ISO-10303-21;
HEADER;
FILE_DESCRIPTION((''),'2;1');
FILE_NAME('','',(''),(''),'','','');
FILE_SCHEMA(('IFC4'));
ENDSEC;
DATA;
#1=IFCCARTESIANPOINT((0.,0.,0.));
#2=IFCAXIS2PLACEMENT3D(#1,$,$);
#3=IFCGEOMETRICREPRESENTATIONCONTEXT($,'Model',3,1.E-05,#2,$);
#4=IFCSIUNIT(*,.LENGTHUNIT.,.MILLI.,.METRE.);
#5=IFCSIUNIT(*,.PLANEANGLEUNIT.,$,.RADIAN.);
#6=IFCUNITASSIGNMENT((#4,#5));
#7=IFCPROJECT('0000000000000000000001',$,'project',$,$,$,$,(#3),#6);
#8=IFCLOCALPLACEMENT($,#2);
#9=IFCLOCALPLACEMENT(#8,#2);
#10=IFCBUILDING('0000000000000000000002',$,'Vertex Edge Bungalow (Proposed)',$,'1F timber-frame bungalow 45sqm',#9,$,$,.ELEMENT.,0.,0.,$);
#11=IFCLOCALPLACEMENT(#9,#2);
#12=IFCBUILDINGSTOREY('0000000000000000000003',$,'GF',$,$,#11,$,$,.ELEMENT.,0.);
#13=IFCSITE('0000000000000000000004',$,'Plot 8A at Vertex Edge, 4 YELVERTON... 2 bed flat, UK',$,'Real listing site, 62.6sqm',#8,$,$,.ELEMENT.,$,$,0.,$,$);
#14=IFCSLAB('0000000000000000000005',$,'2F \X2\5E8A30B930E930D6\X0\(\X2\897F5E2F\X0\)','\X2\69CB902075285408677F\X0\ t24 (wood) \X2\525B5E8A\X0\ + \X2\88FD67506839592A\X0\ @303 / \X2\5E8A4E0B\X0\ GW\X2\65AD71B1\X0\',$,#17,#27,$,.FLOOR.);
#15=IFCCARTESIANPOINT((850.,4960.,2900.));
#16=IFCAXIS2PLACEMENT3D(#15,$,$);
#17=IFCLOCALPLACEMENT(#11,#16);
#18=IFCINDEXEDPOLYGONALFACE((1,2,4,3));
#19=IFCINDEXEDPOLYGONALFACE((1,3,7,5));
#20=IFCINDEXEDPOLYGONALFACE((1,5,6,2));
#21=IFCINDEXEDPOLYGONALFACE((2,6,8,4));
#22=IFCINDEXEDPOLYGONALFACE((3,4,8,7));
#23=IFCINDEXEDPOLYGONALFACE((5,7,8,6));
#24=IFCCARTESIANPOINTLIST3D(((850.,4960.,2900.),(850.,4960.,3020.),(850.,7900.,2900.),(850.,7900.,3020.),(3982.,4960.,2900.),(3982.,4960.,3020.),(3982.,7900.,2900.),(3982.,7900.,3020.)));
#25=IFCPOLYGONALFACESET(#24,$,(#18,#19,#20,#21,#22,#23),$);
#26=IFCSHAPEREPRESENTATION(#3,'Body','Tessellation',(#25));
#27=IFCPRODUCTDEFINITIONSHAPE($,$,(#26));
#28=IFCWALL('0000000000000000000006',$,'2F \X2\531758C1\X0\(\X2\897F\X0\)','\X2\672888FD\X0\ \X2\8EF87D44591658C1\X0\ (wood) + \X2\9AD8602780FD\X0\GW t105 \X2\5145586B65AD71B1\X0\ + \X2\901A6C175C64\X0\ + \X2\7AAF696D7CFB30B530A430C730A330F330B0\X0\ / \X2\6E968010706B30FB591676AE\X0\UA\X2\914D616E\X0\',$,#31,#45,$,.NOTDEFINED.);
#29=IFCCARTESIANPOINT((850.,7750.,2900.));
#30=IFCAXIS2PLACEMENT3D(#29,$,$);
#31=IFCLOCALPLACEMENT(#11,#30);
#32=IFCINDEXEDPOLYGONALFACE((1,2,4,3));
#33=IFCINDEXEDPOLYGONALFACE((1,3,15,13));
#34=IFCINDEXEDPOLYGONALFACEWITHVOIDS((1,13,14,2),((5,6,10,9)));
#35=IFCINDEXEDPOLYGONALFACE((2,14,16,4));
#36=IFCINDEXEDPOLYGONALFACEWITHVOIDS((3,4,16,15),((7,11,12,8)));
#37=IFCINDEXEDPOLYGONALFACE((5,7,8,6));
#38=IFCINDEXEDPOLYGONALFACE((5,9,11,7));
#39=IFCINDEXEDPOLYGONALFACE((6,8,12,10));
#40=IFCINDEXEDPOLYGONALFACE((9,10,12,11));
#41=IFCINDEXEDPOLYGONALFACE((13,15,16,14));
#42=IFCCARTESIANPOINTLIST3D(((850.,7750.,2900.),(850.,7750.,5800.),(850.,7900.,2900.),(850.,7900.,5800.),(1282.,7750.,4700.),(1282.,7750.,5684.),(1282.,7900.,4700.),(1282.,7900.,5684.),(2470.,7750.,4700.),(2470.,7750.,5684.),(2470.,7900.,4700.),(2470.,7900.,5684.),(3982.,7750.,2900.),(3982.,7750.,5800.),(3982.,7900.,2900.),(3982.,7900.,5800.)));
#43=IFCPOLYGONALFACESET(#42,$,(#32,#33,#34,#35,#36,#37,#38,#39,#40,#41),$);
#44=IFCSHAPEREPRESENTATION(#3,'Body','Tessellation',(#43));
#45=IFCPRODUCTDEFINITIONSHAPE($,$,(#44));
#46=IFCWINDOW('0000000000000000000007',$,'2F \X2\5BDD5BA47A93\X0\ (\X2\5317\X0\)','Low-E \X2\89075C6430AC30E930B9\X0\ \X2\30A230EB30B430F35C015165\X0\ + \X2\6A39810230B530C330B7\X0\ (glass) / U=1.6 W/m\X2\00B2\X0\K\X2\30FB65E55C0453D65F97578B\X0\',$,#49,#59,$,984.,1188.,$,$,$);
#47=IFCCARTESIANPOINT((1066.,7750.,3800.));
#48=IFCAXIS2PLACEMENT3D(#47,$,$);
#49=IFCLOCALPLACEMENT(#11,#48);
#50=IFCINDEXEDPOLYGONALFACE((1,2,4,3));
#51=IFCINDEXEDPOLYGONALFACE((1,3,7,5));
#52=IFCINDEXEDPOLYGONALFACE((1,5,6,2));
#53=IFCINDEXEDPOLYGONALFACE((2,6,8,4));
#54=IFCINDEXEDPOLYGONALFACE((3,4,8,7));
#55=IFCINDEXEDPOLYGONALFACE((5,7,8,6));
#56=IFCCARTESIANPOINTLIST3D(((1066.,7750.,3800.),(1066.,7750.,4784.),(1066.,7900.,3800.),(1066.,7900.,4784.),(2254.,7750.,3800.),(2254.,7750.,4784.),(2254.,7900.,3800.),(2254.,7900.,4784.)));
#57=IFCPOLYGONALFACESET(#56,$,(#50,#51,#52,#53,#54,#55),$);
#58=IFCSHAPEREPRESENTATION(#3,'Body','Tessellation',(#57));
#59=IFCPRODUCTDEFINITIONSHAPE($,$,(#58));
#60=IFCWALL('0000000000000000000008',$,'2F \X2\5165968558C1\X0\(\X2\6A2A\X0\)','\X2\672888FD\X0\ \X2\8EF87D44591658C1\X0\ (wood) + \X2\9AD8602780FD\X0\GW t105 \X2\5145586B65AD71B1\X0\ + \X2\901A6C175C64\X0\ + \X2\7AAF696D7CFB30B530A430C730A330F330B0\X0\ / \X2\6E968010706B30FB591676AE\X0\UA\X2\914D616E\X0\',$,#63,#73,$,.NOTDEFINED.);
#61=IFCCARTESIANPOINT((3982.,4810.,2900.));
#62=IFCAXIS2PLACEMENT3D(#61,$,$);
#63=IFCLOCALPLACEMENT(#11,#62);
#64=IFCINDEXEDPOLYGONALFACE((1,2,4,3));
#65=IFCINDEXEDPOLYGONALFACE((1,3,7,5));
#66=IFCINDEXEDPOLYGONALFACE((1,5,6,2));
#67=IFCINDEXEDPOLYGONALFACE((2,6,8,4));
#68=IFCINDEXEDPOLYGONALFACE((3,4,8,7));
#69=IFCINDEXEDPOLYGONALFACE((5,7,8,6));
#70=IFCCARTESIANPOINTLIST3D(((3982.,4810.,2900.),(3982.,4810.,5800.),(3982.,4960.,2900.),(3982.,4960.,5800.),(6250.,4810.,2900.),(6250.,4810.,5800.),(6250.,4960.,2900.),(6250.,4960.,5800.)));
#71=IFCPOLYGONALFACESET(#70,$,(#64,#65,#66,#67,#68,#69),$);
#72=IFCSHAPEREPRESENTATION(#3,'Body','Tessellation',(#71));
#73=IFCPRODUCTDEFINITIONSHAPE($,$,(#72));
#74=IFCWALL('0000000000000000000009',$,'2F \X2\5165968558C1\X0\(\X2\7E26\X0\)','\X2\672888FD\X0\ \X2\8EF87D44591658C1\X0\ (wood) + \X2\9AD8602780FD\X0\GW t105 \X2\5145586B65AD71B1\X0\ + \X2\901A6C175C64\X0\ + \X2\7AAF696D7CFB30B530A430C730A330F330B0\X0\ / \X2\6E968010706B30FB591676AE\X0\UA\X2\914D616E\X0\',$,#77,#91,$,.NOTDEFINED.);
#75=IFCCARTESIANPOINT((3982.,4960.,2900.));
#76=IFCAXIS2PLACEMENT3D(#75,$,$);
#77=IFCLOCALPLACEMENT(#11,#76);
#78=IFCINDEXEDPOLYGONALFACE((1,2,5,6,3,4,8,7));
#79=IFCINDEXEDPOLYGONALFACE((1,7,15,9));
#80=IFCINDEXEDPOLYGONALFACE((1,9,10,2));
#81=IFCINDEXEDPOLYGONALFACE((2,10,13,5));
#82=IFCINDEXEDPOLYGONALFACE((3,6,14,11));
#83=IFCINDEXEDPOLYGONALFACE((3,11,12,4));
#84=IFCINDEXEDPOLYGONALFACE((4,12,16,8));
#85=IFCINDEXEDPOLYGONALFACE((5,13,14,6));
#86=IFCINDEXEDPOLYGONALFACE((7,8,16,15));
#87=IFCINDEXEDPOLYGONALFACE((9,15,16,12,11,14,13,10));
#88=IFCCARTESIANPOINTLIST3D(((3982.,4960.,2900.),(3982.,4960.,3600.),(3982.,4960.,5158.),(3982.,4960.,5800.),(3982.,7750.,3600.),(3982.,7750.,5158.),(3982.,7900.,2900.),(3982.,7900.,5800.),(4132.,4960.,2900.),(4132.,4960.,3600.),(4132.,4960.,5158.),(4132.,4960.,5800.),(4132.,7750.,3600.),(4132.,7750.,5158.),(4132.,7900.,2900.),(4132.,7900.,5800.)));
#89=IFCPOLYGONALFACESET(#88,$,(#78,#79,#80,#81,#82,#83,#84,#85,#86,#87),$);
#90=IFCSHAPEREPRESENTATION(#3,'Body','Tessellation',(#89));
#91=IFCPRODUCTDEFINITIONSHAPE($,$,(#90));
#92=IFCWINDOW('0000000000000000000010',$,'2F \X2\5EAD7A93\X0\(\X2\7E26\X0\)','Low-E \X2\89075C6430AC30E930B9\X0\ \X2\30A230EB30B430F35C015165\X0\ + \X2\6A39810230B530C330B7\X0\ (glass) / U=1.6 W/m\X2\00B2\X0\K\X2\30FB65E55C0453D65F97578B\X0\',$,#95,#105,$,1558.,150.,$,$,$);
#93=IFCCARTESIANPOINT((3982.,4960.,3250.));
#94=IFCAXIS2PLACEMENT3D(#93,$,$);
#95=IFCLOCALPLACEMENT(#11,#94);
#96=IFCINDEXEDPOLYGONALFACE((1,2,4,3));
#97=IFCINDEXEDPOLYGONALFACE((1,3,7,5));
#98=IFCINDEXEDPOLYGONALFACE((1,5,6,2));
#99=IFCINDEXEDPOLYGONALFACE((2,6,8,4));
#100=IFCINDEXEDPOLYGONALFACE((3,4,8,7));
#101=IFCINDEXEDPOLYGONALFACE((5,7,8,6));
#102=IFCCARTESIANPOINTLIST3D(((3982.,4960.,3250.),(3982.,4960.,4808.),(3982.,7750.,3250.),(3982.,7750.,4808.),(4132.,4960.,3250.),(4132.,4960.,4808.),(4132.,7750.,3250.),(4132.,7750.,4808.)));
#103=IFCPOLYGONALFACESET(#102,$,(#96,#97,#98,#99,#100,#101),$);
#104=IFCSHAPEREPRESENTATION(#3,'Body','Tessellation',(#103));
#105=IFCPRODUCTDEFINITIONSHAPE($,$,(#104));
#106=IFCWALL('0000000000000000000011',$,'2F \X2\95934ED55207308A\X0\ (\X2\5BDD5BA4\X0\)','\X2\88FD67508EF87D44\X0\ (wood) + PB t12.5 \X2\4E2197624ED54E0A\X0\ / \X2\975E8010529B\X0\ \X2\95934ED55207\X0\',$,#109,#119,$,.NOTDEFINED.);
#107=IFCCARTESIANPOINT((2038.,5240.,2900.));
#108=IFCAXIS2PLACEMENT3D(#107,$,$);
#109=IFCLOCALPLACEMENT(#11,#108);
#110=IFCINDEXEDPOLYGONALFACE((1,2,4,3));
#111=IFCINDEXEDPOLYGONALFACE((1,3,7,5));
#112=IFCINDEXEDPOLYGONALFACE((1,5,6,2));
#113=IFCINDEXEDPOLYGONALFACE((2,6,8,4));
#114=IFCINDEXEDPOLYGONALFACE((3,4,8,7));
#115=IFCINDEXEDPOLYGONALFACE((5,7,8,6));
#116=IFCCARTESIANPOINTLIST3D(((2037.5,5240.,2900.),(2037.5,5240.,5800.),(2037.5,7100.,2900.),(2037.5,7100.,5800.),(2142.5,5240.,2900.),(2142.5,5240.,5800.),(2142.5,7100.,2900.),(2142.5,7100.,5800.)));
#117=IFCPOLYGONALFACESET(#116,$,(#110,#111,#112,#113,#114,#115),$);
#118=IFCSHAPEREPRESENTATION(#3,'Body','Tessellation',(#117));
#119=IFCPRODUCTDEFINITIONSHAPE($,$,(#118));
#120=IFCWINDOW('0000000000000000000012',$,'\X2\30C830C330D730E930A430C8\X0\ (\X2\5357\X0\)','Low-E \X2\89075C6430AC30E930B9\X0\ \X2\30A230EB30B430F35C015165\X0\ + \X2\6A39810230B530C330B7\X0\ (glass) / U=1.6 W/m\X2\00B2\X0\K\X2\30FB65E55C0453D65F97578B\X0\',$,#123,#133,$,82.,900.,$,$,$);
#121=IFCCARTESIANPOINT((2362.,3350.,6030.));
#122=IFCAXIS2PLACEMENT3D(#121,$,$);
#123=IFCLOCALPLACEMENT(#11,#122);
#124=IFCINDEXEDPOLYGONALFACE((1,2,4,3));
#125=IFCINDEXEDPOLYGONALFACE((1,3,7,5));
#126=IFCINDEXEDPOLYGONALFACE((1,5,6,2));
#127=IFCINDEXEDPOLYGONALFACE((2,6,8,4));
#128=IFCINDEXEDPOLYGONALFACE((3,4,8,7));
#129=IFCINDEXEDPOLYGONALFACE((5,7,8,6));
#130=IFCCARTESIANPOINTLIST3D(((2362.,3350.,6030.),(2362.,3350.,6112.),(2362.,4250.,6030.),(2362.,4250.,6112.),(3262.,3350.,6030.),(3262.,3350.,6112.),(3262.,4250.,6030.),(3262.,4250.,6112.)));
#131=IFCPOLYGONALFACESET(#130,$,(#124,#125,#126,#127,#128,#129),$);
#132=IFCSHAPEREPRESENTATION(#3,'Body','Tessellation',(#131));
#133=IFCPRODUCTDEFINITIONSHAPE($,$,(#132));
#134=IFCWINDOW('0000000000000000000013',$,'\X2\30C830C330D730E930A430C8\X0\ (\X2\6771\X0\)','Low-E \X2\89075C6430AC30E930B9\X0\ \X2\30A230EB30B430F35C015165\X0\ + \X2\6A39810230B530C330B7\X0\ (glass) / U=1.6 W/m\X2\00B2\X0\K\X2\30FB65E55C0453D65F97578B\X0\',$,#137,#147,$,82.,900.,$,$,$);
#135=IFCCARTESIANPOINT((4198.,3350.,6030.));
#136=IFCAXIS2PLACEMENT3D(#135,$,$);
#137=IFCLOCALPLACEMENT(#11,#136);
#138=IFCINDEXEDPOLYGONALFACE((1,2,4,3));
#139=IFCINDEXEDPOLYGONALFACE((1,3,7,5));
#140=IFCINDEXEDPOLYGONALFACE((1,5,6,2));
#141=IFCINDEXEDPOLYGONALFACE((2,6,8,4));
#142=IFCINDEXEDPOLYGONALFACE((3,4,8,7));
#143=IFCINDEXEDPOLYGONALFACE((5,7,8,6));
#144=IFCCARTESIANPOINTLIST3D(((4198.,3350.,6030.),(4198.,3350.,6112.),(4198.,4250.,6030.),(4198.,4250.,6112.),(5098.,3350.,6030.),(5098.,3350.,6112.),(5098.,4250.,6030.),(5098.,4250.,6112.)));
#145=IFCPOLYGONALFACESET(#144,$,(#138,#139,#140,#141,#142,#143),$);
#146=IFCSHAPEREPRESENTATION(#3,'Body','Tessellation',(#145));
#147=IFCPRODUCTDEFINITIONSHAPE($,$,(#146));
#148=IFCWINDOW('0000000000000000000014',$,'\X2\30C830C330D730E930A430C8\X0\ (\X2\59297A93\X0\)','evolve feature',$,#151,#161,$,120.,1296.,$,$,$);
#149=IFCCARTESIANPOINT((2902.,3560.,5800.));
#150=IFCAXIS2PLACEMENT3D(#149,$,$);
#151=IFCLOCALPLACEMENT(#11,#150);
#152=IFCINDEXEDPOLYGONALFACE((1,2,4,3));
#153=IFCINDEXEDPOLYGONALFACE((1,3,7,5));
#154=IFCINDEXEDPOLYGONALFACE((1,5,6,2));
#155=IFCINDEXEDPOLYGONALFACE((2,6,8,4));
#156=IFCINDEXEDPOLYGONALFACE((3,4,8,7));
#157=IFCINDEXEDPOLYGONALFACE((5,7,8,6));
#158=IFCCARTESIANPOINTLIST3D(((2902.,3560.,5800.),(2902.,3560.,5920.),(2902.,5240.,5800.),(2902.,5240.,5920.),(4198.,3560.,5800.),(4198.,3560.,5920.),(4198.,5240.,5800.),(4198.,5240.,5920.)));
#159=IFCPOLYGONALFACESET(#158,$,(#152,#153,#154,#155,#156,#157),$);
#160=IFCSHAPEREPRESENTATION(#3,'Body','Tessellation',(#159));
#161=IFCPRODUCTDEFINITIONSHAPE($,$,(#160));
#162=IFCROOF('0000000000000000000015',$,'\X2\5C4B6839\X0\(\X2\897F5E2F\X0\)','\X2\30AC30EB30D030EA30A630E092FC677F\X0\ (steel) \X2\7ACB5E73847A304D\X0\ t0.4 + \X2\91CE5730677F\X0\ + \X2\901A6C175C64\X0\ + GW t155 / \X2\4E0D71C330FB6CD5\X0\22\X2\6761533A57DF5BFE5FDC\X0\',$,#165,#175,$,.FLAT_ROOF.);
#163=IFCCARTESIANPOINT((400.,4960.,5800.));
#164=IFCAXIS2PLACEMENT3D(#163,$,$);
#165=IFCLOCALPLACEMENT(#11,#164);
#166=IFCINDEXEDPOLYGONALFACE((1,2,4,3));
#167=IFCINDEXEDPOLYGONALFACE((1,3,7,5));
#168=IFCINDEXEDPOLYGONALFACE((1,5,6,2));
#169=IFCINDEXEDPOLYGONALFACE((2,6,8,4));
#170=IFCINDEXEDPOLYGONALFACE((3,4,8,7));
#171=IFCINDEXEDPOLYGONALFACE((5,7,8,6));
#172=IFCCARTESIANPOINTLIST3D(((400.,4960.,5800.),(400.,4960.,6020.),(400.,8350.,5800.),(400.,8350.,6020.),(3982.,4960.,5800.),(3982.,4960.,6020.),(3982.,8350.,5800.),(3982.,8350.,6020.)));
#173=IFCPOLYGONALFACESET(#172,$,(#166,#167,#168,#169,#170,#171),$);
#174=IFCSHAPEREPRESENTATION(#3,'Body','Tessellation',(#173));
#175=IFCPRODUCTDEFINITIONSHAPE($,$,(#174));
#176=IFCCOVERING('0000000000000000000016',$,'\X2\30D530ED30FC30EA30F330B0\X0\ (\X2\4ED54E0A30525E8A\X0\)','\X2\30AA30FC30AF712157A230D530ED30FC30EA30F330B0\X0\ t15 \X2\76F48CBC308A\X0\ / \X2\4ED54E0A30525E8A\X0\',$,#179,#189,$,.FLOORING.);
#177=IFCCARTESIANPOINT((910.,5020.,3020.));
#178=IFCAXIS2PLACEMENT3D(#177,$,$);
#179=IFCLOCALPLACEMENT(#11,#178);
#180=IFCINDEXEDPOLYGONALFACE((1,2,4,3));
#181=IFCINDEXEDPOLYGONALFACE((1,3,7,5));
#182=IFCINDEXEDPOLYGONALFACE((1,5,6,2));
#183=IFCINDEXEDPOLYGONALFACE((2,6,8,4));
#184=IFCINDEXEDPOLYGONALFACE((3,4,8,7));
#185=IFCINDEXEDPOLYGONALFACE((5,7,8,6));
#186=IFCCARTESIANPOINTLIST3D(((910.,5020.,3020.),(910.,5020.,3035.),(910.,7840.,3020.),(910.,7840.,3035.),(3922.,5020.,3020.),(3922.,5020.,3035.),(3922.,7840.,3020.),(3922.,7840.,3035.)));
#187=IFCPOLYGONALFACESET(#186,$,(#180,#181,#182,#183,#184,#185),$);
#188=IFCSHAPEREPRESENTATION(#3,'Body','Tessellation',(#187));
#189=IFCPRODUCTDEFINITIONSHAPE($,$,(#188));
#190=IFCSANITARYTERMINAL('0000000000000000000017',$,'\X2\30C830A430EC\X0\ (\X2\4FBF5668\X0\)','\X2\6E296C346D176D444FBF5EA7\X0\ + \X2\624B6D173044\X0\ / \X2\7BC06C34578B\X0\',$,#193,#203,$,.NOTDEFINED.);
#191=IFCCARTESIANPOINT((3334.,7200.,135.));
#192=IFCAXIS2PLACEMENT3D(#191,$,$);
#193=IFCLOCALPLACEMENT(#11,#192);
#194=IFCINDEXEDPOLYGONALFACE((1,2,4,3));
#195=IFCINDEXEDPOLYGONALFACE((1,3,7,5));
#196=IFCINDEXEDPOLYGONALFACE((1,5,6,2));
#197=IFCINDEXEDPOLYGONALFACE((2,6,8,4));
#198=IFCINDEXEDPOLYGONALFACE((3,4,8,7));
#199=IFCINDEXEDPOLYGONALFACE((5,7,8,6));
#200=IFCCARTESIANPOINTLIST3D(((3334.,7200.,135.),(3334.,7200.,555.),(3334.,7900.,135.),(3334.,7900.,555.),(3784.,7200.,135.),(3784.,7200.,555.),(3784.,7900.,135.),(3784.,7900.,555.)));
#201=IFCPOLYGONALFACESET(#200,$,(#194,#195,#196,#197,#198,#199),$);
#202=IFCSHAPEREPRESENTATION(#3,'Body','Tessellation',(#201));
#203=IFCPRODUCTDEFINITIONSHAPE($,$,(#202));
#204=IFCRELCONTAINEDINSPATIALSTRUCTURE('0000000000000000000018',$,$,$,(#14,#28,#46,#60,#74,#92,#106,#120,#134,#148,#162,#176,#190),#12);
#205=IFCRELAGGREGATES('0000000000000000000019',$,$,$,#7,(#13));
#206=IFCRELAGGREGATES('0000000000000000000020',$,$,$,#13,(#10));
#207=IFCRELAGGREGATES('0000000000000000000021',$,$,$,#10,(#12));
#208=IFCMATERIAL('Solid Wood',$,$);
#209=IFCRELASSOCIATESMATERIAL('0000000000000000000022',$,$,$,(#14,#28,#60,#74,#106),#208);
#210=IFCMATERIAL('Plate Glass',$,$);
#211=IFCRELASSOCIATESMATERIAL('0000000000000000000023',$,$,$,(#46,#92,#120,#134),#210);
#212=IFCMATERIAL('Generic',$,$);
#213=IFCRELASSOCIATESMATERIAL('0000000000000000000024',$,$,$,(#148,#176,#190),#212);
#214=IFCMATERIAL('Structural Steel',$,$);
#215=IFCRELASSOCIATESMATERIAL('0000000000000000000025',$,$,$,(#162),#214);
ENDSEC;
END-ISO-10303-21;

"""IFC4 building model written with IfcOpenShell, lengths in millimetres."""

from ifc_helpers import new_model, si_unit, frame, frame_2d, origin, place, context, project, spatial, rectangle, extrude, material, element, fill, save


model = new_model("IFC4")

# Units and contexts
model_context = context("Model", 3, precision=1e-05, world=origin())
ifc_project = project(units=[si_unit("LENGTHUNIT", "METRE", prefix="MILLI"), si_unit("PLANEANGLEUNIT", "RADIAN")], contexts=[model_context])

# Site, building, storey
site_placement = place(None, origin())
site = spatial("IfcSite", under=ifc_project, at=site_placement, Name="Plot 8A at Vertex Edge, 4 YELVERTON... 2 bed flat, UK", ObjectType="Real listing site, 62.6sqm", CompositionType="ELEMENT", RefElevation=0.0)
building_placement = place(site_placement, origin())
building = spatial("IfcBuilding", under=site, at=building_placement, Name="Vertex Edge Bungalow (Proposed)", ObjectType="1F timber-frame bungalow 45sqm", CompositionType="ELEMENT", ElevationOfRefHeight=0.0, ElevationOfTerrain=0.0)
storey_placement = place(building_placement, origin())
storey = spatial("IfcBuildingStorey", under=building, at=storey_placement, Name="GF", CompositionType="ELEMENT", Elevation=0.0)

# Slab
ifc_material_1 = material(Name="Solid Wood")
slab_placement = place(storey_placement, frame((850.0, 4960.0, 2900.0)))
element("IfcSlab", 1, at=slab_placement, inside=storey, material=ifc_material_1, Name="2F 床スラブ(西帯)", Description="構造用合板 t24 (wood) 剛床 + 製材根太 @303 / 床下 GW断熱", PredefinedType="FLOOR", context=model_context, shape_type="SweptSolid", body=[
    extrude(rectangle(XDim=3132.0, YDim=2940.0, at=frame_2d((1566.0, 1470.0))), frame((850.0, 4960.0, 2900.0)), (0.0, 0.0, 1.0), 120.0),
])

# Wall, opening, window
wall_1_placement = place(storey_placement, frame((850.0, 7750.0, 2900.0)))
wall_1 = element("IfcWall", 2, at=wall_1_placement, inside=storey, material=ifc_material_1, Name="2F 北壁(西)", Description="木製 軸組外壁 (wood) + 高性能GW t105 充填断熱 + 通気層 + 窯業系サイディング / 準耐火・外皮UA配慮", PredefinedType="NOTDEFINED", context=model_context, shape_type="SweptSolid", body=[
    extrude(rectangle(XDim=3132.0, YDim=150.0, at=frame_2d((1566.0, 75.0))), frame((850.0, 7750.0, 2900.0)), (0.0, 0.0, 1.0), 2900.0),
])
opening_1_placement = place(storey_placement, frame((1066.0, 7750.0, 3800.0)))
opening_1 = element("IfcOpeningElement", 3, at=opening_1_placement, cuts=wall_1, PredefinedType="NOTDEFINED", context=model_context, shape_type="SweptSolid", body=[
    extrude(rectangle(XDim=1188.0, YDim=150.0, at=frame_2d((594.0, 75.0))), frame((1066.0, 7750.0, 3800.0)), (0.0, 0.0, 1.0), 984.0),
])
ifc_material_2 = material(Name="Plate Glass")
window_1_placement = place(storey_placement, frame((1066.0, 7750.0, 3800.0)))
window_1 = element("IfcWindow", 4, at=window_1_placement, inside=storey, material=ifc_material_2, Name="2F 寝室窓 (北)", Description="Low-E 複層ガラス アルゴン封入 + 樹脂サッシ (glass) / U=1.6 W/m²K・日射取得型", OverallHeight=984.0, OverallWidth=1188.0, context=model_context, shape_type="SweptSolid", body=[
    extrude(rectangle(XDim=1188.0, YDim=150.0, at=frame_2d((594.0, 75.0))), frame((1066.0, 7750.0, 3800.0)), (0.0, 0.0, 1.0), 984.0),
])
fill(opening_1, window_1)

# Wall
wall_2_placement = place(storey_placement, frame((3982.0, 4810.0, 2900.0)))
element("IfcWall", 5, at=wall_2_placement, inside=storey, material=ifc_material_1, Name="2F 入隅壁(横)", Description="木製 軸組外壁 (wood) + 高性能GW t105 充填断熱 + 通気層 + 窯業系サイディング / 準耐火・外皮UA配慮", PredefinedType="NOTDEFINED", context=model_context, shape_type="SweptSolid", body=[
    extrude(rectangle(XDim=2268.0, YDim=150.0, at=frame_2d((1134.0, 75.0))), frame((3982.0, 4810.0, 2900.0)), (0.0, 0.0, 1.0), 2900.0),
])

# Wall, opening, window
wall_3_placement = place(storey_placement, frame((3982.0, 4960.0, 2900.0)))
wall_3 = element("IfcWall", 6, at=wall_3_placement, inside=storey, material=ifc_material_1, Name="2F 入隅壁(縦)", Description="木製 軸組外壁 (wood) + 高性能GW t105 充填断熱 + 通気層 + 窯業系サイディング / 準耐火・外皮UA配慮", PredefinedType="NOTDEFINED", context=model_context, shape_type="SweptSolid", body=[
    extrude(rectangle(XDim=150.0, YDim=2940.0, at=frame_2d((75.0, 1470.0))), frame((3982.0, 4960.0, 2900.0)), (0.0, 0.0, 1.0), 2900.0),
])
opening_2_placement = place(storey_placement, frame((3982.0, 4960.0, 3250.0)))
opening_2 = element("IfcOpeningElement", 7, at=opening_2_placement, cuts=wall_3, PredefinedType="NOTDEFINED", context=model_context, shape_type="SweptSolid", body=[
    extrude(rectangle(XDim=150.0, YDim=2790.0, at=frame_2d((75.0, 1395.0))), frame((3982.0, 4960.0, 3250.0)), (0.0, 0.0, 1.0), 1558.0),
])
window_2_placement = place(storey_placement, frame((3982.0, 4960.0, 3250.0)))
window_2 = element("IfcWindow", 8, at=window_2_placement, inside=storey, material=ifc_material_2, Name="2F 庭窓(縦)", Description="Low-E 複層ガラス アルゴン封入 + 樹脂サッシ (glass) / U=1.6 W/m²K・日射取得型", OverallHeight=1558.0, OverallWidth=150.0, context=model_context, shape_type="SweptSolid", body=[
    extrude(rectangle(XDim=150.0, YDim=2790.0, at=frame_2d((75.0, 1395.0))), frame((3982.0, 4960.0, 3250.0)), (0.0, 0.0, 1.0), 1558.0),
])
fill(opening_2, window_2)

# Wall
wall_4_placement = place(storey_placement, frame((2038.0, 5240.0, 2900.0)))
element("IfcWall", 9, at=wall_4_placement, inside=storey, material=ifc_material_1, Name="2F 間仕切り (寝室)", Description="製材軸組 (wood) + PB t12.5 両面仕上 / 非耐力 間仕切", PredefinedType="NOTDEFINED", context=model_context, shape_type="SweptSolid", body=[
    extrude(rectangle(XDim=105.0, YDim=1860.0, at=frame_2d((52.0, 930.0))), frame((2038.0, 5240.0, 2900.0)), (0.0, 0.0, 1.0), 2900.0),
])

# Windows
window_3_placement = place(storey_placement, frame((2362.0, 3350.0, 6030.0)))
element("IfcWindow", 10, at=window_3_placement, inside=storey, material=ifc_material_2, Name="トップライト (南)", Description="Low-E 複層ガラス アルゴン封入 + 樹脂サッシ (glass) / U=1.6 W/m²K・日射取得型", OverallHeight=82.0, OverallWidth=900.0, context=model_context, shape_type="SweptSolid", body=[
    extrude(rectangle(XDim=900.0, YDim=900.0, at=frame_2d((450.0, 450.0))), frame((2362.0, 3350.0, 6030.0)), (0.0, 0.0, 1.0), 82.0),
])
window_4_placement = place(storey_placement, frame((4198.0, 3350.0, 6030.0)))
element("IfcWindow", 11, at=window_4_placement, inside=storey, material=ifc_material_2, Name="トップライト (東)", Description="Low-E 複層ガラス アルゴン封入 + 樹脂サッシ (glass) / U=1.6 W/m²K・日射取得型", OverallHeight=82.0, OverallWidth=900.0, context=model_context, shape_type="SweptSolid", body=[
    extrude(rectangle(XDim=900.0, YDim=900.0, at=frame_2d((450.0, 450.0))), frame((4198.0, 3350.0, 6030.0)), (0.0, 0.0, 1.0), 82.0),
])
ifc_material_3 = material(Name="Generic")
window_5_placement = place(storey_placement, frame((2902.0, 3560.0, 5800.0)))
element("IfcWindow", 12, at=window_5_placement, inside=storey, material=ifc_material_3, Name="トップライト (天窓)", Description="evolve feature", OverallHeight=120.0, OverallWidth=1296.0, context=model_context, shape_type="SweptSolid", body=[
    extrude(rectangle(XDim=1296.0, YDim=1680.0, at=frame_2d((648.0, 840.0))), frame((2902.0, 3560.0, 5800.0)), (0.0, 0.0, 1.0), 120.0),
])

# Roof
ifc_material_4 = material(Name="Structural Steel")
for number, where, name in (
    (13, (400.0, 4960.0, 5800.0), "屋根(西帯)"),
):
    element("IfcRoof", number, at=place(storey_placement, frame(where)), inside=storey, material=ifc_material_4, Name=name, Description="ガルバリウム鋼板 (steel) 立平葺き t0.4 + 野地板 + 通気層 + GW t155 / 不燃・法22条区域対応", PredefinedType="FLAT_ROOF", context=model_context, shape_type="SweptSolid", body=[
        extrude(rectangle(XDim=3582.0, YDim=3390.0, at=frame_2d((1791.0, 1695.0))), frame((400.0, 4960.0, 5800.0)), (0.0, 0.0, 1.0), 220.0),
    ])

# Covering
covering_placement = place(storey_placement, frame((910.0, 5020.0, 3020.0)))
element("IfcCovering", 14, at=covering_placement, inside=storey, material=ifc_material_3, Name="フローリング (仕上げ床)", Description="オーク無垢フローリング t15 直貼り / 仕上げ床", PredefinedType="FLOORING", context=model_context, shape_type="SweptSolid", body=[
    extrude(rectangle(XDim=3012.0, YDim=2820.0, at=frame_2d((1506.0, 1410.0))), frame((910.0, 5020.0, 3020.0)), (0.0, 0.0, 1.0), 15.0),
])

# Sanitary terminal
sanitary_terminal_placement = place(storey_placement, frame((3334.0, 7200.0, 135.0)))
element("IfcSanitaryTerminal", 15, at=sanitary_terminal_placement, inside=storey, material=ifc_material_3, Name="トイレ (便器)", Description="温水洗浄便座 + 手洗い / 節水型", PredefinedType="NOTDEFINED", context=model_context, shape_type="SweptSolid", body=[
    extrude(rectangle(XDim=450.0, YDim=700.0, at=frame_2d((225.0, 350.0))), frame((3334.0, 7200.0, 135.0)), (0.0, 0.0, 1.0), 420.0),
])

save(model, "model.ifc")
